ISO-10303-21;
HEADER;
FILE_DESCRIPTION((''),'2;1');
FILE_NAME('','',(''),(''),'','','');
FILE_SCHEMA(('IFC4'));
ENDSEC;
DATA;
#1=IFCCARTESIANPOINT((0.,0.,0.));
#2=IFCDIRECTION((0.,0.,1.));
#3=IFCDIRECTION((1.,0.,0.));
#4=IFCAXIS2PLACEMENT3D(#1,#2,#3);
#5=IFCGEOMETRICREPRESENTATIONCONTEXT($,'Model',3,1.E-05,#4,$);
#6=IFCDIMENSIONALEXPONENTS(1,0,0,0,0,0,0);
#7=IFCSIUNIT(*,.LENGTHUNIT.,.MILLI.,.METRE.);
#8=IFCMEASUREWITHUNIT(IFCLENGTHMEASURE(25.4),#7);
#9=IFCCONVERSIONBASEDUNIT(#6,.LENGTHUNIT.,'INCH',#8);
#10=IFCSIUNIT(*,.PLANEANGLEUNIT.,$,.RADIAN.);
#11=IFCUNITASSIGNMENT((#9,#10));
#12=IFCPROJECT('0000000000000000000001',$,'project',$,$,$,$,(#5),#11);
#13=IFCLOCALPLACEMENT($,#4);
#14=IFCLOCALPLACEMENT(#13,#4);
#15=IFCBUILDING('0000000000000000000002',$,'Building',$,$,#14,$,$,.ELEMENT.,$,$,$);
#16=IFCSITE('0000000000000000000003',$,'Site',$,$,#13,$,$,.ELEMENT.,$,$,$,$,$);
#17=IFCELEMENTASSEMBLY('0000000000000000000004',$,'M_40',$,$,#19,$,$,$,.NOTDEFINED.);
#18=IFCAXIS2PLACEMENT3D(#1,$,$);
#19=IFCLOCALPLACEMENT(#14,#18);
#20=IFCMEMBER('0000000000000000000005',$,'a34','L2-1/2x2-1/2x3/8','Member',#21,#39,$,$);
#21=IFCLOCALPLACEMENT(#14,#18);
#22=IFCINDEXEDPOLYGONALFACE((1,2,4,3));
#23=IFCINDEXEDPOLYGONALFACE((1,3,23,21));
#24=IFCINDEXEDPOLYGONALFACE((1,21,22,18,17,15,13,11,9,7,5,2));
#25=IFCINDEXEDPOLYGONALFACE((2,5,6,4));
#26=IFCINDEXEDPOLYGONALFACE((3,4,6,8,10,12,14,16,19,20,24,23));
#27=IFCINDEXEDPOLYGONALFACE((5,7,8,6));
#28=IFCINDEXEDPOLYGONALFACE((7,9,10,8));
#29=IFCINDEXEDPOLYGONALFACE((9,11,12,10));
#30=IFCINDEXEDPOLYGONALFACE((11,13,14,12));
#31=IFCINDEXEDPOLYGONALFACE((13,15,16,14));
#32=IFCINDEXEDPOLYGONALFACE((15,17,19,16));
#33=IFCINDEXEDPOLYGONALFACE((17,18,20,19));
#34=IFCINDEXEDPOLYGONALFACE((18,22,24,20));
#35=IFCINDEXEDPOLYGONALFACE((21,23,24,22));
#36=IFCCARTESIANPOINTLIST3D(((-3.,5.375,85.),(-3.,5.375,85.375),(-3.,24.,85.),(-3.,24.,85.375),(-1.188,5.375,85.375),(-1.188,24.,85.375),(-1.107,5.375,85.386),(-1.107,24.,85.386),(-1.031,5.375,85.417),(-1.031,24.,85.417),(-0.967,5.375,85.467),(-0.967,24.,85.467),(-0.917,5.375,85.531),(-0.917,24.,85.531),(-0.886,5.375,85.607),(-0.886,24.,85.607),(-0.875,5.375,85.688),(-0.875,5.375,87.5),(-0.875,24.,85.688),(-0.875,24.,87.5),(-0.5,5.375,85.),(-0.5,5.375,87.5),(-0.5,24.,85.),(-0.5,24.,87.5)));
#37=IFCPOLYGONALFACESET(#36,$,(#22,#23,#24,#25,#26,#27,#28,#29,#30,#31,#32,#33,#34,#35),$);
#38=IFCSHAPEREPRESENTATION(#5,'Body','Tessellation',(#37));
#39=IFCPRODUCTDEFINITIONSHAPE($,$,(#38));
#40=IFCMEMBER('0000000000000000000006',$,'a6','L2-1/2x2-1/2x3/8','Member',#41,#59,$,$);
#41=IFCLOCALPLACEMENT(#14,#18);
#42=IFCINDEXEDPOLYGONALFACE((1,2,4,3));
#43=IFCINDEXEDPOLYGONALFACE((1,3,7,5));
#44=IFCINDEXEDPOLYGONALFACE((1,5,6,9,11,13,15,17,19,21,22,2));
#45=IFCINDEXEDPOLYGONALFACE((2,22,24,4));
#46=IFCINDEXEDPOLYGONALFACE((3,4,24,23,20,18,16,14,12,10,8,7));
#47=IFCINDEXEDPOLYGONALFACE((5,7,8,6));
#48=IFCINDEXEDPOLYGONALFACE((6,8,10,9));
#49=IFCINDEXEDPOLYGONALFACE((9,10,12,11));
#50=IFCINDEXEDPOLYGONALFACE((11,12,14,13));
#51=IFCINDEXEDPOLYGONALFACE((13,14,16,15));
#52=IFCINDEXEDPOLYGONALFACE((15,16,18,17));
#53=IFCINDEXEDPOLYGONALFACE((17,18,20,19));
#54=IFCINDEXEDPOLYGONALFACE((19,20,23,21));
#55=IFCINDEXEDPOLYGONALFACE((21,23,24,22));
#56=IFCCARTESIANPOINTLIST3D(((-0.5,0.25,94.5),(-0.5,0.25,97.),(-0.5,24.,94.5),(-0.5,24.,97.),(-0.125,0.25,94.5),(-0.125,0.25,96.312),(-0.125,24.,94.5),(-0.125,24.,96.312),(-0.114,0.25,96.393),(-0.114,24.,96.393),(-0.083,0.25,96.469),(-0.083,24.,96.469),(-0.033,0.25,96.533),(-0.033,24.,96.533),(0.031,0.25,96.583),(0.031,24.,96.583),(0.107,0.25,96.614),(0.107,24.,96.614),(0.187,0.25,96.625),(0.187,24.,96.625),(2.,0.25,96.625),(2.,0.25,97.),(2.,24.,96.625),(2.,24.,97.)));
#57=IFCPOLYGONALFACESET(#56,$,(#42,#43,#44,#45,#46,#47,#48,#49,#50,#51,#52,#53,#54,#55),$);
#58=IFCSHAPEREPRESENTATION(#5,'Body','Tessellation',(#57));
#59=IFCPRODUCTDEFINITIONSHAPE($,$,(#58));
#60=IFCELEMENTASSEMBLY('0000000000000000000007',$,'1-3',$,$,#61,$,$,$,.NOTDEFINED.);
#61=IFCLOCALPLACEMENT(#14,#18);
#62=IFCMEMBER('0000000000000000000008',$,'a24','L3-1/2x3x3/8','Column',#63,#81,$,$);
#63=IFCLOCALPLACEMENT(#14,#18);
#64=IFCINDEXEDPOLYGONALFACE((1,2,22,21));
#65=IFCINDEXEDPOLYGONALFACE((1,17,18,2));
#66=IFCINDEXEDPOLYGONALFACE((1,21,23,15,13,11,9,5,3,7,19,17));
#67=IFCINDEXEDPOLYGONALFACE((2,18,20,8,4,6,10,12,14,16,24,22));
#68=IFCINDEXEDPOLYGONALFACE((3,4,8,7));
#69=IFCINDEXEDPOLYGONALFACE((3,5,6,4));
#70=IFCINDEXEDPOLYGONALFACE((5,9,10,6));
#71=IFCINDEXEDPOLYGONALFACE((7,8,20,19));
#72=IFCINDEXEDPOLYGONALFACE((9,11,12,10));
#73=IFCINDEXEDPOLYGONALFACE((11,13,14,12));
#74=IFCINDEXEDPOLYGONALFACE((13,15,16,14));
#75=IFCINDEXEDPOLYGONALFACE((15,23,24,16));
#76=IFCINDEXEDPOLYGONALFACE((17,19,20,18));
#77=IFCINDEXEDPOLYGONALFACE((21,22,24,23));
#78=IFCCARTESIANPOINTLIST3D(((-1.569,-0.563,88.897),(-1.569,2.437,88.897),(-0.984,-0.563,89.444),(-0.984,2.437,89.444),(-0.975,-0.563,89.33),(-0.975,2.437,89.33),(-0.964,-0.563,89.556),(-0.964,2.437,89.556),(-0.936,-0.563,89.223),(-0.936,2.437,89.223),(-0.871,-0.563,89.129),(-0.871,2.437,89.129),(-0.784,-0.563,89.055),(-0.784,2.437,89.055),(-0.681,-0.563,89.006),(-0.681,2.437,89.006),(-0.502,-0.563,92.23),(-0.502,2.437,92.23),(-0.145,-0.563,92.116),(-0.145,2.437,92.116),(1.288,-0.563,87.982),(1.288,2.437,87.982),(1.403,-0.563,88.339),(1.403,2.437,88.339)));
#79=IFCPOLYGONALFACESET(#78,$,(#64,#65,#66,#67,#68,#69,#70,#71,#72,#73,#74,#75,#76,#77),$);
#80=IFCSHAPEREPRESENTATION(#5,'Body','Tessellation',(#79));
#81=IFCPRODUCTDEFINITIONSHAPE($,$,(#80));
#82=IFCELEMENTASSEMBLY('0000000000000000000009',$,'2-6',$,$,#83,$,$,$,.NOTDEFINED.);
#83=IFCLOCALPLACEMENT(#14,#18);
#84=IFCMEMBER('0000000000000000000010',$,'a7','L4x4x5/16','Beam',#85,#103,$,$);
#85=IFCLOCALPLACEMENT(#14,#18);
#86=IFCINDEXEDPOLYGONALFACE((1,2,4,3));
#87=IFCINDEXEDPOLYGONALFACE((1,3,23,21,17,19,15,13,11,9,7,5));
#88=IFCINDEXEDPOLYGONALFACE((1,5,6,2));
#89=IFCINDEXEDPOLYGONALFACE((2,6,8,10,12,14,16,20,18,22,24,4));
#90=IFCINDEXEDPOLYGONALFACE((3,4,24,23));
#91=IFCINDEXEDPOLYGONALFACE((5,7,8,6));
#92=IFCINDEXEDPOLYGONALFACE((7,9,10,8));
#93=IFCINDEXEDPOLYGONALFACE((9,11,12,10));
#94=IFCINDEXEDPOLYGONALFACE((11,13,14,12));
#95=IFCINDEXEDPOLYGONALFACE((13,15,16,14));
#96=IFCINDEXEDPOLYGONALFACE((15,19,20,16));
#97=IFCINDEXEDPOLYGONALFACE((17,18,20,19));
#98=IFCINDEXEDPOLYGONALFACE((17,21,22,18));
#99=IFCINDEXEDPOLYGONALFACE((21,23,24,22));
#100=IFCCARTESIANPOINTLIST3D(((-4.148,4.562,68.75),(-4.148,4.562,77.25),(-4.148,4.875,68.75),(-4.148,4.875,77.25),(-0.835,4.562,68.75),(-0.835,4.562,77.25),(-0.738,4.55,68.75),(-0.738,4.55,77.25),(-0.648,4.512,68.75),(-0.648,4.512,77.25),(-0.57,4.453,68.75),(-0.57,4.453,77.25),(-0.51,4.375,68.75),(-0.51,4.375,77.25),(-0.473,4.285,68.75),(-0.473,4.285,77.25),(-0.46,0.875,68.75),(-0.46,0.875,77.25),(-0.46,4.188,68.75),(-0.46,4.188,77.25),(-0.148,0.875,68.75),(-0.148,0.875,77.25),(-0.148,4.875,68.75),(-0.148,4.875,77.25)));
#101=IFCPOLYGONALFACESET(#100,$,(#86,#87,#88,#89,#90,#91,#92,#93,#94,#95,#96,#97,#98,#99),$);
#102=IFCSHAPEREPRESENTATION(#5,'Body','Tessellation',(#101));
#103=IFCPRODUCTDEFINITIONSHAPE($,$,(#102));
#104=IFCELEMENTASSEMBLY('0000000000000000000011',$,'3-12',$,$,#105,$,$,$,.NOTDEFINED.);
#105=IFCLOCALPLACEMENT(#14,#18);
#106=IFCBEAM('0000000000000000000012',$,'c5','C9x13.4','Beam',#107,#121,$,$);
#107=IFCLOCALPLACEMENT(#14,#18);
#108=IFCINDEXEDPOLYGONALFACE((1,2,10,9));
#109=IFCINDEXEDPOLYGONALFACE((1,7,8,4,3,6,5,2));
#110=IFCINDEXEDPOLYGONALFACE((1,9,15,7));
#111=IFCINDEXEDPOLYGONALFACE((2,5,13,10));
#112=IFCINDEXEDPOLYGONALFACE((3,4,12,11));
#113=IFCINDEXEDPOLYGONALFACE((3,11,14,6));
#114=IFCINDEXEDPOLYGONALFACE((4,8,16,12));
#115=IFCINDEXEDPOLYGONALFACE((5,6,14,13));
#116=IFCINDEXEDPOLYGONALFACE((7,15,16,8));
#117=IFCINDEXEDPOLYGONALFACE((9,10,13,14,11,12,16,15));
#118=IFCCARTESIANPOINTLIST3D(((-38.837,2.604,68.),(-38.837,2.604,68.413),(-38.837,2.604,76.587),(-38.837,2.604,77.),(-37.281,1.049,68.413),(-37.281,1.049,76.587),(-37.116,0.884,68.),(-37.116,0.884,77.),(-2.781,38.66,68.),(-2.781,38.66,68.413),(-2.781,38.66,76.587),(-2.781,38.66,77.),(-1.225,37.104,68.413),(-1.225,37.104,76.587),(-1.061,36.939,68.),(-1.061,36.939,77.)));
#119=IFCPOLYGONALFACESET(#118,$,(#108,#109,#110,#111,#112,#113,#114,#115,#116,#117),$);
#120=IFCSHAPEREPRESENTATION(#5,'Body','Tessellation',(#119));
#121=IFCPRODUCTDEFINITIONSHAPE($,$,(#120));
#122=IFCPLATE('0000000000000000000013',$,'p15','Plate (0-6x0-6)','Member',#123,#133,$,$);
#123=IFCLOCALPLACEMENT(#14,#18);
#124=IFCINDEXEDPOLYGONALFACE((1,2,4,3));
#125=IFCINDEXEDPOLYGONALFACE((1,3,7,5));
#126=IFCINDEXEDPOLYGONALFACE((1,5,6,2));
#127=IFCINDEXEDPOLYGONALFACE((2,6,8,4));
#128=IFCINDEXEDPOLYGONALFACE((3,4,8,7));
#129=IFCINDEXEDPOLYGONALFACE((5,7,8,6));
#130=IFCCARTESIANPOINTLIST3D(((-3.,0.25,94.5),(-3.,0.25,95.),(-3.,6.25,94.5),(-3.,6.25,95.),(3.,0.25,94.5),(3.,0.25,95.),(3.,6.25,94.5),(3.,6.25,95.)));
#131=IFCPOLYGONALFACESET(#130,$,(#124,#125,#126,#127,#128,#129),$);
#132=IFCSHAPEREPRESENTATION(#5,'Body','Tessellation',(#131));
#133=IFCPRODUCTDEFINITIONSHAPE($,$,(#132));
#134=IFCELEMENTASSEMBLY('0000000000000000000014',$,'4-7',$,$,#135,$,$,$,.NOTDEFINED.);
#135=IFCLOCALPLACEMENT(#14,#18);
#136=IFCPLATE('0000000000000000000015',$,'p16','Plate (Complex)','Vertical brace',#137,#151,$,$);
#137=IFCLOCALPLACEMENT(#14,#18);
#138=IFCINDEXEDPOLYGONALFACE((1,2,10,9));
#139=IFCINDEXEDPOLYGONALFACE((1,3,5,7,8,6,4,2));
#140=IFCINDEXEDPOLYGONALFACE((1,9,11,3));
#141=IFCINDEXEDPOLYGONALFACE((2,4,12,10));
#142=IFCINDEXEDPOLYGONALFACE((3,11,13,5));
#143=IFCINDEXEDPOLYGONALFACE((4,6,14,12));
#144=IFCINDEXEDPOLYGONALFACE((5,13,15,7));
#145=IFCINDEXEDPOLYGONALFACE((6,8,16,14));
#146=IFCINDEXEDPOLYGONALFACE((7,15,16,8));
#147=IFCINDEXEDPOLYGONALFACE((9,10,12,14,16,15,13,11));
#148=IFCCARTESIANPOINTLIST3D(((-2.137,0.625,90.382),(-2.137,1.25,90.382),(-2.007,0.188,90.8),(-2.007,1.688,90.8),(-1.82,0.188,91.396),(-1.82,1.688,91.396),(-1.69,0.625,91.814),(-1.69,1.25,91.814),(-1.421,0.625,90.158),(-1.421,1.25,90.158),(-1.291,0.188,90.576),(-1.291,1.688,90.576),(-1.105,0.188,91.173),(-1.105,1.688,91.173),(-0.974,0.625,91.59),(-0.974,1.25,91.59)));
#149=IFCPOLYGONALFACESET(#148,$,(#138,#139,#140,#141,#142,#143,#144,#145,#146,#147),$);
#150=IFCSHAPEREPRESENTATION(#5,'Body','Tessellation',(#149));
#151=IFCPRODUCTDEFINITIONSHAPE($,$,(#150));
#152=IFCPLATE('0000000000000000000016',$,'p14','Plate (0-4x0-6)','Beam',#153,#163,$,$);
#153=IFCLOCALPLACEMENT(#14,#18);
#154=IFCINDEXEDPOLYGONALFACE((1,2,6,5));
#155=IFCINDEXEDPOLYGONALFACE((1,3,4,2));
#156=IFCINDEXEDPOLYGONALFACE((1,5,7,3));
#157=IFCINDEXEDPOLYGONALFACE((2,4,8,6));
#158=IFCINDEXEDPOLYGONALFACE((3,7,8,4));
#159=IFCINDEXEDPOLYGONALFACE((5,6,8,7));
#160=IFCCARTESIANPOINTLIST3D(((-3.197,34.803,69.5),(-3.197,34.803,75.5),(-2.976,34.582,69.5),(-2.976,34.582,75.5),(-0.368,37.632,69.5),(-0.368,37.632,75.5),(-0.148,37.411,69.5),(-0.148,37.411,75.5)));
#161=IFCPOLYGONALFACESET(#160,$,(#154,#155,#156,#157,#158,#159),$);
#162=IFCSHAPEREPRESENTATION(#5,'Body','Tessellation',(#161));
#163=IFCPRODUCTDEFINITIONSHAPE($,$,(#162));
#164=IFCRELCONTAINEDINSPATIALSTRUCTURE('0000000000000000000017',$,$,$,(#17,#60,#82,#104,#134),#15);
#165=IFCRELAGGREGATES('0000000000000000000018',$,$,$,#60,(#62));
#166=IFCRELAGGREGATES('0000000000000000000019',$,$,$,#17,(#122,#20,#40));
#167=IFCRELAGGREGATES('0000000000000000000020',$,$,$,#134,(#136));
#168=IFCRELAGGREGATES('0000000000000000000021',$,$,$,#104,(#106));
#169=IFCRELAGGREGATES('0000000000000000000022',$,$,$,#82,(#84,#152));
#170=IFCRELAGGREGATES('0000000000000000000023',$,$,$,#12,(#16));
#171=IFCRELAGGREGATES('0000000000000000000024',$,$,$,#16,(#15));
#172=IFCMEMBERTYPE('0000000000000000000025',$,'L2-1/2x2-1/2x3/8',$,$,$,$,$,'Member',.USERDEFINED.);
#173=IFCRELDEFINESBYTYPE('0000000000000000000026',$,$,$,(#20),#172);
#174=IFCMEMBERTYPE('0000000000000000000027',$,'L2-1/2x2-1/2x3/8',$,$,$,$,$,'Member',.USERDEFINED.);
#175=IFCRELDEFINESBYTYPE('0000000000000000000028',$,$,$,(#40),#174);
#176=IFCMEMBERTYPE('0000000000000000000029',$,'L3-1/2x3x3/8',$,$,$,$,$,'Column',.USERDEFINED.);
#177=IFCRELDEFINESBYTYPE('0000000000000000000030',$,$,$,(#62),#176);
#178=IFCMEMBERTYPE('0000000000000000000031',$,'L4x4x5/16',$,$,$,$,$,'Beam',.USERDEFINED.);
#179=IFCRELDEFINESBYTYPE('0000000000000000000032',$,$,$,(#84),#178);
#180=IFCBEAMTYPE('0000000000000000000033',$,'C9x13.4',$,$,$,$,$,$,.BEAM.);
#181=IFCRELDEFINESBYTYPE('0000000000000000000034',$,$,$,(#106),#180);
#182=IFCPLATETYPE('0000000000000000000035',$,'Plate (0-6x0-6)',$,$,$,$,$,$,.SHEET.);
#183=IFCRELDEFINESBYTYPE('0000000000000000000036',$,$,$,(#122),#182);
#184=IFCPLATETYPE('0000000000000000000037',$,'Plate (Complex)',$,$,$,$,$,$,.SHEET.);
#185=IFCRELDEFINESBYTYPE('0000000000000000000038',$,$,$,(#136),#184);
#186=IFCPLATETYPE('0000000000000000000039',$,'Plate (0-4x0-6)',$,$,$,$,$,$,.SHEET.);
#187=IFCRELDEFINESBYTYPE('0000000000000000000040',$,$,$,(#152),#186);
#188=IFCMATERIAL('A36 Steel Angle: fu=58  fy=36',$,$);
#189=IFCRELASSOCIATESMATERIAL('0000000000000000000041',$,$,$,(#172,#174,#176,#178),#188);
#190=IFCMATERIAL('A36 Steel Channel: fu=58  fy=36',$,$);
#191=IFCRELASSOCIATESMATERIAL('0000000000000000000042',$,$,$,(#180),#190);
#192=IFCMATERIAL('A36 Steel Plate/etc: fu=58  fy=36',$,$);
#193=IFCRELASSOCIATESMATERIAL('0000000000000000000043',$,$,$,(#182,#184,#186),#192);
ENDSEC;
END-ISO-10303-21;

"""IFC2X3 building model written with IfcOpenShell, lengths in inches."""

from ifc_helpers import new_model, entity, si_unit, converted_unit, frame, frame_2d, origin_with_axes, place, context, project, spatial, polyline, l_section, u_section, outline, transform_2d, derived_profile, extrude, source, transform, mapped, material, type_object, type_shapes, element, aggregate, save


model = new_model("IFC2X3")

# Units and contexts
model_context = context("Model", 3, precision=1e-05, world=origin_with_axes())
ifc_project = project(units=[converted_unit("LENGTHUNIT", "INCH", entity("IfcLengthMeasure", 25.4), si_unit("LENGTHUNIT", "METRE", prefix="MILLI"), dimensions=[1, 0, 0, 0, 0, 0, 0]), si_unit("PLANEANGLEUNIT", "RADIAN")], contexts=[model_context])

# Site, building
site_placement = place(None, origin_with_axes())
site = spatial("IfcSite", under=ifc_project, at=site_placement, Name="Site", CompositionType="ELEMENT")
building_placement = place(site_placement, origin_with_axes())
building = spatial("IfcBuilding", under=site, at=building_placement, Name="Building", CompositionType="ELEMENT")

# Element assembly, members
assembly_1_placement = place(building_placement, frame((0.0, 0.0, 97.0), z_axis=(0.0, 0.0, -1.0), x_axis=(0.0, 1.0, 0.0)))
assembly_1 = element("IfcElementAssembly", 1, at=assembly_1_placement, inside=building, Name="M_40", PredefinedType="NOTDEFINED")
ifc_material_1 = material(Name="A36 Steel Angle: fu=58  fy=36")
member_type_1 = type_object("IfcMemberType", Name="L2-1/2x2-1/2x3/8", ElementType="Member", PredefinedType="USERDEFINED", material=ifc_material_1)
shared_shape_1 = source(origin_with_axes(), model_context, "Body", "SweptSolid", [
    extrude(l_section(Depth=2.5, Width=2.5, Thickness=0.375, FilletRadius=0.312, at=frame_2d((1.25, 1.25), x_axis=(1.0, 0.0))), frame((0.0, 0.0, 0.0), z_axis=(1.0, 0.0, 0.0), x_axis=(0.0, 1.0, 0.0)), (0.0, 0.0, 1.0), 18.625),
])
type_shapes(member_type_1, [shared_shape_1])
member_1_placement = place(assembly_1_placement, frame((24.0, -0.5, 12.0), z_axis=(0.0, -1.0, 0.0), x_axis=(-1.0, 0.0, 0.0)))
member_1 = element("IfcMember", 2, at=member_1_placement, type_object=member_type_1, Name="a34", Description="L2-1/2x2-1/2x3/8", ObjectType="Member", context=model_context, shape_type="MappedRepresentation", body=[
    mapped(shared_shape_1, transform((0.0, 0.0, 0.0), scale=1.0)),
])
member_type_2 = type_object("IfcMemberType", Name="L2-1/2x2-1/2x3/8", ElementType="Member", PredefinedType="USERDEFINED", material=ifc_material_1)
shared_shape_2 = source(origin_with_axes(), model_context, "Body", "SweptSolid", [
    extrude(derived_profile(l_section(Depth=2.5, Width=2.5, Thickness=0.375, FilletRadius=0.312, at=frame_2d((1.25, 1.25), x_axis=(1.0, 0.0))), transform_2d((0.0, 0.0), x_axis=(-1.0, 0.0), y_axis=(0.0, 1.0))), frame((0.0, 0.0, 0.0), z_axis=(1.0, 0.0, 0.0), x_axis=(0.0, 1.0, 0.0)), (0.0, 0.0, 1.0), 23.75),
])
type_shapes(member_type_2, [shared_shape_2])
member_2_placement = place(assembly_1_placement, frame((0.25, -0.5, 0.0), z_axis=(0.0, 0.0, 1.0), x_axis=(1.0, 0.0, 0.0)))
member_2 = element("IfcMember", 3, at=member_2_placement, type_object=member_type_2, Name="a6", Description="L2-1/2x2-1/2x3/8", ObjectType="Member", context=model_context, shape_type="MappedRepresentation", body=[
    mapped(shared_shape_2, transform((0.0, 0.0, 0.0), scale=1.0)),
])

# Element assemblies, members
assembly_2_placement = place(building_placement, frame((0.0, 0.0, 54.5), z_axis=(0.0, -1.0, 0.0), x_axis=(0.0, 0.0, 1.0)))
assembly_2 = element("IfcElementAssembly", 4, at=assembly_2_placement, inside=building, Name="1-3", PredefinedType="NOTDEFINED")
member_type_3 = type_object("IfcMemberType", Name="L3-1/2x3x3/8", ElementType="Column", PredefinedType="USERDEFINED", material=ifc_material_1)
shared_shape_3 = source(origin_with_axes(), model_context, "Body", "SweptSolid", [
    extrude(l_section(Depth=3.5, Width=3.0, Thickness=0.375, FilletRadius=0.438, at=frame_2d((1.5, 1.75), x_axis=(1.0, 0.0))), frame((0.0, 0.0, 0.0), z_axis=(1.0, 0.0, 0.0), x_axis=(0.0, 1.0, 0.0)), (0.0, 0.0, 1.0), 3.0),
])
type_shapes(member_type_3, [shared_shape_3])
member_3_placement = place(assembly_2_placement, frame((34.397, 1.569, -2.437), z_axis=(0.952396, -0.304864, 0.0), x_axis=(0.0, 0.0, 1.0)))
member_3 = element("IfcMember", 5, at=member_3_placement, type_object=member_type_3, Name="a24", Description="L3-1/2x3x3/8", ObjectType="Column", context=model_context, shape_type="MappedRepresentation", body=[
    mapped(shared_shape_3, transform((0.0, 0.0, 0.0), scale=1.0)),
])
aggregate(assembly_2, [member_3])
assembly_3_placement = place(building_placement, frame((0.0, 0.0, 80.0), z_axis=(0.0, 0.0, 1.0), x_axis=(0.0, 1.0, 0.0)))
assembly_3 = element("IfcElementAssembly", 6, at=assembly_3_placement, inside=building, Name="2-6", PredefinedType="NOTDEFINED")
member_type_4 = type_object("IfcMemberType", Name="L4x4x5/16", ElementType="Beam", PredefinedType="USERDEFINED", material=ifc_material_1)
shared_shape_4 = source(origin_with_axes(), model_context, "Body", "SweptSolid", [
    extrude(derived_profile(l_section(Depth=4.0, Width=4.0, Thickness=0.312, FilletRadius=0.375, at=frame_2d((2.0, 2.0), x_axis=(1.0, 0.0))), transform_2d((0.0, 0.0), x_axis=(-1.0, 0.0), y_axis=(0.0, 1.0))), frame((0.0, 0.0, 0.0), z_axis=(1.0, 0.0, 0.0), x_axis=(0.0, 1.0, 0.0)), (0.0, 0.0, 1.0), 8.5),
])
type_shapes(member_type_4, [shared_shape_4])
member_4_placement = place(assembly_3_placement, frame((4.875, 0.148, -2.75), z_axis=(0.0, 1.0, 0.0), x_axis=(0.0, 0.0, -1.0)))
member_4 = element("IfcMember", 7, at=member_4_placement, type_object=member_type_4, Name="a7", Description="L4x4x5/16", ObjectType="Beam", context=model_context, shape_type="MappedRepresentation", body=[
    mapped(shared_shape_4, transform((0.0, 0.0, 0.0), scale=1.0)),
])

# Element assembly, beam
assembly_4_placement = place(building_placement, frame((-38.0, 0.0, 77.0), z_axis=(0.0, 0.0, 1.0), x_axis=(0.707107, 0.707107, 0.0)))
assembly_4 = element("IfcElementAssembly", 8, at=assembly_4_placement, inside=building, Name="3-12", PredefinedType="NOTDEFINED")
ifc_material_2 = material(Name="A36 Steel Channel: fu=58  fy=36")
beam_type = type_object("IfcBeamType", Name="C9x13.4", PredefinedType="BEAM", material=ifc_material_2)
shared_shape_5 = source(origin_with_axes(), model_context, "Body", "SweptSolid", [
    extrude(u_section(Depth=9.0, FlangeWidth=2.433, WebThickness=0.233, FlangeThickness=0.413, at=frame_2d((1.216, -4.5), x_axis=(1.0, 0.0))), frame((0.0, 0.0, 0.0), z_axis=(1.0, 0.0, 0.0), x_axis=(0.0, 1.0, 0.0)), (0.0, 0.0, 1.0), 50.99),
])
type_shapes(beam_type, [shared_shape_5])
beam_placement = place(assembly_4_placement, frame((1.25, 0.0, 0.0), z_axis=(0.0, 0.0, 1.0), x_axis=(1.0, 0.0, 0.0)))
beam = element("IfcBeam", 9, at=beam_placement, type_object=beam_type, Name="c5", Description="C9x13.4", ObjectType="Beam", context=model_context, shape_type="MappedRepresentation", body=[
    mapped(shared_shape_5, transform((0.0, 0.0, 0.0), scale=1.0)),
])

# Plate
ifc_material_3 = material(Name="A36 Steel Plate/etc: fu=58  fy=36")
plate_type_1 = type_object("IfcPlateType", Name="Plate (0-6x0-6)", PredefinedType="SHEET", material=ifc_material_3)
shared_shape_6 = source(origin_with_axes(), model_context, "Body", "SweptSolid", [
    extrude(outline(polyline([(0.0, -6.0), (-6.0, -6.0), (-6.0, 0.0), (0.0, 0.0), (0.0, -6.0)])), frame((-0.25, 0.0, 0.0), z_axis=(1.0, 0.0, 0.0), x_axis=(0.0, 1.0, 0.0)), (0.0, 0.0, 1.0), 0.5),
])
type_shapes(plate_type_1, [shared_shape_6])
plate_1_placement = place(assembly_1_placement, frame((6.25, -3.0, 2.25), z_axis=(0.0, -1.0, 0.0), x_axis=(0.0, 0.0, -1.0)))
plate_1 = element("IfcPlate", 10, at=plate_1_placement, type_object=plate_type_1, Name="p15", Description="Plate (0-6x0-6)", ObjectType="Member", context=model_context, shape_type="MappedRepresentation", body=[
    mapped(shared_shape_6, transform((0.0, 0.0, 0.0), scale=1.0)),
])
aggregate(assembly_1, [plate_1, member_1, member_2])

# Element assembly, plate
assembly_5_placement = place(building_placement, frame((24.0, 0.938, 83.0), z_axis=(0.0, 1.0, 0.0), x_axis=(-0.95448, 0.0, 0.298275)))
assembly_5 = element("IfcElementAssembly", 11, at=assembly_5_placement, inside=building, Name="4-7", PredefinedType="NOTDEFINED")
plate_type_2 = type_object("IfcPlateType", Name="Plate (Complex)", PredefinedType="SHEET", material=ifc_material_3)
shared_shape_7 = source(origin_with_axes(), model_context, "Body", "SweptSolid", [
    extrude(outline(polyline([(0.0, -1.062), (-0.438, -1.5), (-1.062, -1.5), (-1.5, -1.062), (-1.5, -0.438), (-1.062, 0.0), (-0.438, 0.0), (0.0, -0.438), (0.0, -1.062)])), frame((-0.375, 0.0, 0.0), z_axis=(1.0, 0.0, 0.0), x_axis=(0.0, 1.0, 0.0)), (0.0, 0.0, 1.0), 0.75),
])
type_shapes(plate_type_2, [shared_shape_7])
plate_2_placement = place(assembly_5_placement, frame((26.774, 0.75, 0.75), z_axis=(0.0, 0.0, 1.0), x_axis=(1.0, 0.0, 0.0)))
plate_2 = element("IfcPlate", 12, at=plate_2_placement, type_object=plate_type_2, Name="p16", Description="Plate (Complex)", ObjectType="Vertical brace", context=model_context, shape_type="MappedRepresentation", body=[
    mapped(shared_shape_7, transform((0.0, 0.0, 0.0), scale=1.0)),
])
aggregate(assembly_5, [plate_2])

# Plate
aggregate(assembly_4, [beam])
plate_type_3 = type_object("IfcPlateType", Name="Plate (0-4x0-6)", PredefinedType="SHEET", material=ifc_material_3)
shared_shape_8 = source(origin_with_axes(), model_context, "Body", "SweptSolid", [
    extrude(outline(polyline([(0.0, -4.0), (-6.0, -4.0), (-6.0, 0.0), (0.0, 0.0), (0.0, -4.0)])), frame((-0.156, 0.0, 0.0), z_axis=(1.0, 0.0, 0.0), x_axis=(0.0, 1.0, 0.0)), (0.0, 0.0, 1.0), 0.312),
])
type_shapes(plate_type_3, [shared_shape_8])
plate_3_placement = place(assembly_3_placement, frame((37.521, 0.258, -4.5), z_axis=(0.707107, -0.707107, 0.0), x_axis=(0.707107, 0.707107, 0.0)))
plate_3 = element("IfcPlate", 13, at=plate_3_placement, type_object=plate_type_3, Name="p14", Description="Plate (0-4x0-6)", ObjectType="Beam", context=model_context, shape_type="MappedRepresentation", body=[
    mapped(shared_shape_8, transform((0.0, 0.0, 0.0), scale=1.0)),
])
aggregate(assembly_3, [member_4, plate_3])

save(model, "model.ifc")
